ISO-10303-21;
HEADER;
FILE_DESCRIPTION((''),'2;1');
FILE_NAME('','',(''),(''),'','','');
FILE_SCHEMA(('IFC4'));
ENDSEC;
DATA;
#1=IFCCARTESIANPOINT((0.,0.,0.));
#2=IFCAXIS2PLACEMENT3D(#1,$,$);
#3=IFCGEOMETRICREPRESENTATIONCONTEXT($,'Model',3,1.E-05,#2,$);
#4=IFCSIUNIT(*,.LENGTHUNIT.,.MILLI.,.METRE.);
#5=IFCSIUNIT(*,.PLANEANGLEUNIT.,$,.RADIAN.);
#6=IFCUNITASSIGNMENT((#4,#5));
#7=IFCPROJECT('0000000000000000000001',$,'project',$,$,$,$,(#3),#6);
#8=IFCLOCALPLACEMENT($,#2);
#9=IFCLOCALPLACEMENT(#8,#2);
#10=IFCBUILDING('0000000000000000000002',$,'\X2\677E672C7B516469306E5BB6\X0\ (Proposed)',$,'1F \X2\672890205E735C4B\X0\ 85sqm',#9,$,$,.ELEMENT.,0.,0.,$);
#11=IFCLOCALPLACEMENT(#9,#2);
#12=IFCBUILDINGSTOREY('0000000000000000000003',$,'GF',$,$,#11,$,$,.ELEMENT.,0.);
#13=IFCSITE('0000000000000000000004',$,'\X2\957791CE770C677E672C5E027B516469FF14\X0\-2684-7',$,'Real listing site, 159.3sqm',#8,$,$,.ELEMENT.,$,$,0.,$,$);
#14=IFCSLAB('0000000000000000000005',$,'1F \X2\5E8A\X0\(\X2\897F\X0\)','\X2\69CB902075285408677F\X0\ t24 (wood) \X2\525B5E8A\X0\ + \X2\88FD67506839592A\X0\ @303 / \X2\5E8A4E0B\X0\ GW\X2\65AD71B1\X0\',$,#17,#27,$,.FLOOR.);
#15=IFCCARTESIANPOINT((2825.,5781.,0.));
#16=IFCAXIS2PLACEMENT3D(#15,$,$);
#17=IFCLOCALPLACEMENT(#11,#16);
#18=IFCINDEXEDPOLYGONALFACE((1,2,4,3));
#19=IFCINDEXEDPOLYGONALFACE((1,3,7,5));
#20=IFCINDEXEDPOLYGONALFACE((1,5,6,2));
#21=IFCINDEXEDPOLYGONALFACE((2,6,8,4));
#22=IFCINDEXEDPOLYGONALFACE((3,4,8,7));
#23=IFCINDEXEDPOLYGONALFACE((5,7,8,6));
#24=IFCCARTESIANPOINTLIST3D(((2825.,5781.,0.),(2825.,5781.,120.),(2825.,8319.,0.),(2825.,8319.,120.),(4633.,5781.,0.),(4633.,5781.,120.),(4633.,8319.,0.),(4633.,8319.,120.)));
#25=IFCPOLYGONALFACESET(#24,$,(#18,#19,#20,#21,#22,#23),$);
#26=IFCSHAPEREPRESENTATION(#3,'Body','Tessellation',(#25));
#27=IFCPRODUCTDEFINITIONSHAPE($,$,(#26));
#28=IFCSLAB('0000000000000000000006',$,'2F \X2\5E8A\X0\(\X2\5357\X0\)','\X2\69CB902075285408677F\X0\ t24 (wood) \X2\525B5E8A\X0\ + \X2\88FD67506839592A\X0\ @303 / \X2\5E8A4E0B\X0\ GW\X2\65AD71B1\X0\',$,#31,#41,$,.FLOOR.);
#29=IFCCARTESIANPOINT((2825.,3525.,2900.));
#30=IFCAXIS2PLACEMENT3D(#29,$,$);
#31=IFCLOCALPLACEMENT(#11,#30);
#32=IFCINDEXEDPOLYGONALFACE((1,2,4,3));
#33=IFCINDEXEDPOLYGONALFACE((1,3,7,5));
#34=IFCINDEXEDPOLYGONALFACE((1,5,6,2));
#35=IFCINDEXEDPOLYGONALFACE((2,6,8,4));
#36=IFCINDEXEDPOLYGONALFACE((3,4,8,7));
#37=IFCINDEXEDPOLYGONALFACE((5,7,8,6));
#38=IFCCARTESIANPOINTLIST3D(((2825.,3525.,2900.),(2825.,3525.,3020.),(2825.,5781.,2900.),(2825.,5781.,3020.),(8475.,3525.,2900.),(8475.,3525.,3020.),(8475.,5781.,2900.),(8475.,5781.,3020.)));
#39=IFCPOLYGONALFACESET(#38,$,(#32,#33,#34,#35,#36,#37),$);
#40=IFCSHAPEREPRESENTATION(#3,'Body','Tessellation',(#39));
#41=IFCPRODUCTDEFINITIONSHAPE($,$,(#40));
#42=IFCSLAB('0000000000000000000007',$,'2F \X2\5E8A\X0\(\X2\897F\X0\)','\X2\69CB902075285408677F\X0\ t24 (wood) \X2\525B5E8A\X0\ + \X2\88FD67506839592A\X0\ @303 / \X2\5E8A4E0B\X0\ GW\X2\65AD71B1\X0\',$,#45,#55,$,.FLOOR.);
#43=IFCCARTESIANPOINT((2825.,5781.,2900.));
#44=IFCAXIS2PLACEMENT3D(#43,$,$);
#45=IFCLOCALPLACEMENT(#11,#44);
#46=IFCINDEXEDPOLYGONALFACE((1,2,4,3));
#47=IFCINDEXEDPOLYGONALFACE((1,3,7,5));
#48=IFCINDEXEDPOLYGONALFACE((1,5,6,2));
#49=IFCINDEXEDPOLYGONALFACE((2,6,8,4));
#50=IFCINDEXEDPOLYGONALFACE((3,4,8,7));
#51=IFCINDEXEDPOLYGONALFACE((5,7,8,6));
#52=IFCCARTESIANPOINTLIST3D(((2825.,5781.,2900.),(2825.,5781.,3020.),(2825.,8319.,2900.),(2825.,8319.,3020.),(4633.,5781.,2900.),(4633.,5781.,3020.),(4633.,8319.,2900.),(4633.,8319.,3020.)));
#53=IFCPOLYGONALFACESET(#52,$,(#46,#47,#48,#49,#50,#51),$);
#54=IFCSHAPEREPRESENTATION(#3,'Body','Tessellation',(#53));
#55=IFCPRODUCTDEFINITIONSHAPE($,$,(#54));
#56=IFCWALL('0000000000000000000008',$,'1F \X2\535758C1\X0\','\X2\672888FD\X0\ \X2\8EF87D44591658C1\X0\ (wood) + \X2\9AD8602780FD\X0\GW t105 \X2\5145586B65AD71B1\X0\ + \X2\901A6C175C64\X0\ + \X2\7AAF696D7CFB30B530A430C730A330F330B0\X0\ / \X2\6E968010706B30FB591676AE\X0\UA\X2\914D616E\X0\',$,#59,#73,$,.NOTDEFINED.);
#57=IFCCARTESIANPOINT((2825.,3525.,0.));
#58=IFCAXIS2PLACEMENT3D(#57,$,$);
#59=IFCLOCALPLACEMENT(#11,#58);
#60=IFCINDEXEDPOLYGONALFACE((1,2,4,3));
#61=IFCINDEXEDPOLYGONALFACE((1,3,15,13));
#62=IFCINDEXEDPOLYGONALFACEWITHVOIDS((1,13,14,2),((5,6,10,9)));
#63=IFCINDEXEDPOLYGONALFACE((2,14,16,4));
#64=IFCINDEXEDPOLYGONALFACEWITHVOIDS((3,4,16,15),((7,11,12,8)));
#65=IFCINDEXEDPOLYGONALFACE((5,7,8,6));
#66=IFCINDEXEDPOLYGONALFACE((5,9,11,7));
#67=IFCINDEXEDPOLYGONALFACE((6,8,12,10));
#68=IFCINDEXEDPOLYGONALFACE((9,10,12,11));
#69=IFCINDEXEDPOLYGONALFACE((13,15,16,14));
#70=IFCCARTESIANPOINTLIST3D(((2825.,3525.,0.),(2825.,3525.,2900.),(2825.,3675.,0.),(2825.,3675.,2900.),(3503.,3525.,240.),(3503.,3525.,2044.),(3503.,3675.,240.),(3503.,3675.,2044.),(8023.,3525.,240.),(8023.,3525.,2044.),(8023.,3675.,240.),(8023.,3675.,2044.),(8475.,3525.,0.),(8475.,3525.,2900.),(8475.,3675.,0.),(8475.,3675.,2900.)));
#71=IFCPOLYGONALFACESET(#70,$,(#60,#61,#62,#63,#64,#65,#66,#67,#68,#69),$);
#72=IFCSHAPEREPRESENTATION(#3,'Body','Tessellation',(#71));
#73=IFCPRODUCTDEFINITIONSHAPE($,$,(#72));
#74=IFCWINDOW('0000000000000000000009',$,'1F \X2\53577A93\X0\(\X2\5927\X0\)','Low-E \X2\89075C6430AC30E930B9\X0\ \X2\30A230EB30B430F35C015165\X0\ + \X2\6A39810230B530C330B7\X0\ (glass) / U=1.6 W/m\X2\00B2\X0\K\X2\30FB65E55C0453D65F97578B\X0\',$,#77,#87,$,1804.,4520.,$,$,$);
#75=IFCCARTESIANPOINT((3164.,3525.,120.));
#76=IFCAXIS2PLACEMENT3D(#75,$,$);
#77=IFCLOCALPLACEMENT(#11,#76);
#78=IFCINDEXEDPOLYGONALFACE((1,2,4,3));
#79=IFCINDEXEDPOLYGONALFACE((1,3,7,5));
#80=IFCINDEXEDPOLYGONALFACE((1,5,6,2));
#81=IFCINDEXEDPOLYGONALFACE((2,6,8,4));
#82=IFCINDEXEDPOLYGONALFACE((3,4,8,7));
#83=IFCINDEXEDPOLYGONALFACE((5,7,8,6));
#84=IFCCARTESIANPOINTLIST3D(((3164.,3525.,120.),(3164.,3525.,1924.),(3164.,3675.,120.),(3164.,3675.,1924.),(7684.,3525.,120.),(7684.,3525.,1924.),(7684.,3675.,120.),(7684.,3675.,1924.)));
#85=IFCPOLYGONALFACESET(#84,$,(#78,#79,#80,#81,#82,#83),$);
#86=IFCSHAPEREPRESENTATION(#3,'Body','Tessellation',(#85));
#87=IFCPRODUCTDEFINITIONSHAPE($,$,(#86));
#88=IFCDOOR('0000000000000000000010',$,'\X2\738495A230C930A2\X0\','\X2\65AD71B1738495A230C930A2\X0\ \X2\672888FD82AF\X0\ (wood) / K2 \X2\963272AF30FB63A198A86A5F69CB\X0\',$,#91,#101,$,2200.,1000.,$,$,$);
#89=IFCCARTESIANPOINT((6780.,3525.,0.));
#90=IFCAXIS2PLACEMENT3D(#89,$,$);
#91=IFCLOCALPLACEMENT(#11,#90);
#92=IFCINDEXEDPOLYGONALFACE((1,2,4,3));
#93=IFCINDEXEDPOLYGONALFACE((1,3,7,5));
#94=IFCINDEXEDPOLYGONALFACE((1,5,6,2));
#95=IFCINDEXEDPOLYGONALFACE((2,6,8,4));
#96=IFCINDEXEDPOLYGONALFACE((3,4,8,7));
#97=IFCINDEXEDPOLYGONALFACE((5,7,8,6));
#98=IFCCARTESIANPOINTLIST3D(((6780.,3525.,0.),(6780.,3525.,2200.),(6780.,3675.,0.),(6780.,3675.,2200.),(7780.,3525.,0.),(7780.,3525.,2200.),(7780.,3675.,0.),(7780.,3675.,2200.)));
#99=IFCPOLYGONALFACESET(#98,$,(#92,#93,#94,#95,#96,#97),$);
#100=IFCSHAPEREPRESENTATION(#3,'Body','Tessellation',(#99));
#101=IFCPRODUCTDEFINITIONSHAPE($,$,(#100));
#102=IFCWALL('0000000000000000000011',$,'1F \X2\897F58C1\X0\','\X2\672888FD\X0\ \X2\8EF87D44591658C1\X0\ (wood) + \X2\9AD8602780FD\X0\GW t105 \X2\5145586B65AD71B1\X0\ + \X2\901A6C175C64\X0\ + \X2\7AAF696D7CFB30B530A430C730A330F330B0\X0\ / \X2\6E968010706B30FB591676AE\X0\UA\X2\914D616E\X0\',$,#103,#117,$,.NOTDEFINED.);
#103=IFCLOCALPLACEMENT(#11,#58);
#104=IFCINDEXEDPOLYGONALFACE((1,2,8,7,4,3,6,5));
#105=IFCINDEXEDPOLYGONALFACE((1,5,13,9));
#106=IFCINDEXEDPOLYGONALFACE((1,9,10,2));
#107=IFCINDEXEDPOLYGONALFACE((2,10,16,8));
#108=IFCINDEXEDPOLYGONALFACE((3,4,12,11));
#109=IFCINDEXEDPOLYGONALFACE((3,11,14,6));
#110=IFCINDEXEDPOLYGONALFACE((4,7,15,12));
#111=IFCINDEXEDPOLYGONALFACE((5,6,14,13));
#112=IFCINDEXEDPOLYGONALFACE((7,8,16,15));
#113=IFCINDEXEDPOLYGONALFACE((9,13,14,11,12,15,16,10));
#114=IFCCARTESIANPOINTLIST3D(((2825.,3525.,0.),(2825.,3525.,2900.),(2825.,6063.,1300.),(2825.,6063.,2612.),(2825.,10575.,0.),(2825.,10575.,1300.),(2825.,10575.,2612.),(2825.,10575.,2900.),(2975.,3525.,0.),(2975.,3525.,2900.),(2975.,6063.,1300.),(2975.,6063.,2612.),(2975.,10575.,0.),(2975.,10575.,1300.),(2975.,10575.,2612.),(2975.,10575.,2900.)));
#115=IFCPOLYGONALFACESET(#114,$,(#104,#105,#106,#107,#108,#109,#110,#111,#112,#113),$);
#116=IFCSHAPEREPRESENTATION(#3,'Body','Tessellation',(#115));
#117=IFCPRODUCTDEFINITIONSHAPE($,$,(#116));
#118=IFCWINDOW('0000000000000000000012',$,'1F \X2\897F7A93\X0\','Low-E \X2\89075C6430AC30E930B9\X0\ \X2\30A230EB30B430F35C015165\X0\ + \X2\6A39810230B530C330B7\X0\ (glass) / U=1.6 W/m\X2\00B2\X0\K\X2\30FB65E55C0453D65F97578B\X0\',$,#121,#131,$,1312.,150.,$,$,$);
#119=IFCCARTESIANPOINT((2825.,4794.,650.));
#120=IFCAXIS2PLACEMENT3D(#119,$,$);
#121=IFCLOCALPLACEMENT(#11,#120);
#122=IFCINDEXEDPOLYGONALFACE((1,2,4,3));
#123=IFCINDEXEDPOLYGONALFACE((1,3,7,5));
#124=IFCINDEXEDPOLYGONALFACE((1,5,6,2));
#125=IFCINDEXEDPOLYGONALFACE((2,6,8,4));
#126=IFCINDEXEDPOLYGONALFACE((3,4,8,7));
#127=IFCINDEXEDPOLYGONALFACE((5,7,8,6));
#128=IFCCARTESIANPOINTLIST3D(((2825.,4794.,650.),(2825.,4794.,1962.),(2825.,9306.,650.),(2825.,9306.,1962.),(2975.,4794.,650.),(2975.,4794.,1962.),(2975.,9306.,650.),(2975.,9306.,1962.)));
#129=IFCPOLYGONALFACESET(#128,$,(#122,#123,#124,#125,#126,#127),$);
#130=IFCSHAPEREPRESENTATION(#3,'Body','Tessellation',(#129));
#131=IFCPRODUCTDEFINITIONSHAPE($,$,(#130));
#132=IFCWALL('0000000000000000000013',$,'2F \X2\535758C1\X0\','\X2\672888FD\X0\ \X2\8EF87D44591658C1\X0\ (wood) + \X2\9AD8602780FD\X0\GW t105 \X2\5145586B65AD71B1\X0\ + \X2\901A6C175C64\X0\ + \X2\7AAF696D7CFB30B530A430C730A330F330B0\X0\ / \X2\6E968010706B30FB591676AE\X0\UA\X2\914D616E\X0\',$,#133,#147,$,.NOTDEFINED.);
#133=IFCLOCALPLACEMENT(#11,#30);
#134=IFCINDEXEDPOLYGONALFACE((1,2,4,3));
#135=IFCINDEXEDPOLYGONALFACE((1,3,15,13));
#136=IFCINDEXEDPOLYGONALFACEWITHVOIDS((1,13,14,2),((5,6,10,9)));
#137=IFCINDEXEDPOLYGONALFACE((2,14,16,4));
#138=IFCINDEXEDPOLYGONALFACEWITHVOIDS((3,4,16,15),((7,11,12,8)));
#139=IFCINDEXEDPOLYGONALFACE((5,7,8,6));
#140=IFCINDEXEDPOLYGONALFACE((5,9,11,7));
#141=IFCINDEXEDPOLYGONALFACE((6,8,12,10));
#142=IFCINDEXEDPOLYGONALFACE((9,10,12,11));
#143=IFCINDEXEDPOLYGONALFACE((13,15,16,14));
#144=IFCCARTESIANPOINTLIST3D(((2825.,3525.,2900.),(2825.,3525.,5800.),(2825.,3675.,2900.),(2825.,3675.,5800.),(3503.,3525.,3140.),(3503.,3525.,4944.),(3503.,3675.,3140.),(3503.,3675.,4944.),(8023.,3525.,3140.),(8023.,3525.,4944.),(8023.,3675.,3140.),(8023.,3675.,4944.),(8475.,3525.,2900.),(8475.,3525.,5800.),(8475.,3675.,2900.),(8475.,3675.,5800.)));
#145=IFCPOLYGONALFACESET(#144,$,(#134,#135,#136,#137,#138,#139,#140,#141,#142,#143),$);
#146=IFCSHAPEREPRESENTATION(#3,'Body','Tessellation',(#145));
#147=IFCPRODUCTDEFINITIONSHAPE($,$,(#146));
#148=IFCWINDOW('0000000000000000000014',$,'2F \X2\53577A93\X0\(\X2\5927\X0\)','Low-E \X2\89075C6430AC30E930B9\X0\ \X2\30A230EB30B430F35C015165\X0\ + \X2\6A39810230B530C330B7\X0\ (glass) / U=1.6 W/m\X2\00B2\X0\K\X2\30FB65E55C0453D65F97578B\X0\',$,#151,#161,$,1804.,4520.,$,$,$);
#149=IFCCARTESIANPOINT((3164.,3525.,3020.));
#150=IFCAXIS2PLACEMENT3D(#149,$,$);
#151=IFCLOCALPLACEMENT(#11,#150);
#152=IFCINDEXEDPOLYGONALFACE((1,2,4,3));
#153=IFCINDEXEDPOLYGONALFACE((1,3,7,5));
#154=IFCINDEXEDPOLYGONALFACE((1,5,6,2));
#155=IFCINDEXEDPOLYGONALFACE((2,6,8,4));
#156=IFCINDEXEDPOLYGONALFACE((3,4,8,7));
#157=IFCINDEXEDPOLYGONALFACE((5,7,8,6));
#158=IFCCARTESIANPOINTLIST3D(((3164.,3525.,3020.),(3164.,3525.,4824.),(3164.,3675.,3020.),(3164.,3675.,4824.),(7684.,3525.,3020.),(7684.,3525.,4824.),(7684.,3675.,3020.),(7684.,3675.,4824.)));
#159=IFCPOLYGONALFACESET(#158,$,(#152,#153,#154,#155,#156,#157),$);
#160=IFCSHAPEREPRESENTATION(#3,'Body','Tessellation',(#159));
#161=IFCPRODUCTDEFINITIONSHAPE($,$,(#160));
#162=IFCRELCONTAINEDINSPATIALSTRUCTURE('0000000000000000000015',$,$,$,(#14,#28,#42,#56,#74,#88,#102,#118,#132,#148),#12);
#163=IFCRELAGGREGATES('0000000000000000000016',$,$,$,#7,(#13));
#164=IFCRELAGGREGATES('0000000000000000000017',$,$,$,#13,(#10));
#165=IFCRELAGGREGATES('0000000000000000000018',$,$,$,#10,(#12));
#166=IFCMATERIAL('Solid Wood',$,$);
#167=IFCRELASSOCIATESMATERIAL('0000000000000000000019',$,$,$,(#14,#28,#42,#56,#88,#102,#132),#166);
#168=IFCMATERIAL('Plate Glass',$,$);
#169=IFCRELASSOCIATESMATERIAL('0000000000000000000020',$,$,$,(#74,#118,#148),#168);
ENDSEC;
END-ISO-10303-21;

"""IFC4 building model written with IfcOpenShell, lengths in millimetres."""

from ifc_helpers import new_model, si_unit, frame, frame_2d, origin, place, context, project, spatial, rectangle, extrude, material, element, fill, save


model = new_model("IFC4")

# Units and contexts
model_context = context("Model", 3, precision=1e-05, world=origin())
ifc_project = project(units=[si_unit("LENGTHUNIT", "METRE", prefix="MILLI"), si_unit("PLANEANGLEUNIT", "RADIAN")], contexts=[model_context])

# Site, building, storey
site_placement = place(None, origin())
site = spatial("IfcSite", under=ifc_project, at=site_placement, Name="長野県松本市筑摩４-2684-7", ObjectType="Real listing site, 159.3sqm", CompositionType="ELEMENT", RefElevation=0.0)
building_placement = place(site_placement, origin())
building = spatial("IfcBuilding", under=site, at=building_placement, Name="松本筑摩の家 (Proposed)", ObjectType="1F 木造平屋 85sqm", CompositionType="ELEMENT", ElevationOfRefHeight=0.0, ElevationOfTerrain=0.0)
storey_placement = place(building_placement, origin())
storey = spatial("IfcBuildingStorey", under=building, at=storey_placement, Name="GF", CompositionType="ELEMENT", Elevation=0.0)

# Slabs
ifc_material_1 = material(Name="Solid Wood")
slab_1_placement = place(storey_placement, frame((2825.0, 5781.0, 0.0)))
element("IfcSlab", 1, at=slab_1_placement, inside=storey, material=ifc_material_1, Name="1F 床(西)", Description="構造用合板 t24 (wood) 剛床 + 製材根太 @303 / 床下 GW断熱", PredefinedType="FLOOR", context=model_context, shape_type="SweptSolid", body=[
    extrude(rectangle(XDim=1808.0, YDim=2538.0, at=frame_2d((904.0, 1269.0))), frame((2825.0, 5781.0, 0.0)), (0.0, 0.0, 1.0), 120.0),
])
slab_2_placement = place(storey_placement, frame((2825.0, 3525.0, 2900.0)))
element("IfcSlab", 2, at=slab_2_placement, inside=storey, material=ifc_material_1, Name="2F 床(南)", Description="構造用合板 t24 (wood) 剛床 + 製材根太 @303 / 床下 GW断熱", PredefinedType="FLOOR", context=model_context, shape_type="SweptSolid", body=[
    extrude(rectangle(XDim=5650.0, YDim=2256.0, at=frame_2d((2825.0, 1128.0))), frame((2825.0, 3525.0, 2900.0)), (0.0, 0.0, 1.0), 120.0),
])
slab_3_placement = place(storey_placement, frame((2825.0, 5781.0, 2900.0)))
element("IfcSlab", 3, at=slab_3_placement, inside=storey, material=ifc_material_1, Name="2F 床(西)", Description="構造用合板 t24 (wood) 剛床 + 製材根太 @303 / 床下 GW断熱", PredefinedType="FLOOR", context=model_context, shape_type="SweptSolid", body=[
    extrude(rectangle(XDim=1808.0, YDim=2538.0, at=frame_2d((904.0, 1269.0))), frame((2825.0, 5781.0, 2900.0)), (0.0, 0.0, 1.0), 120.0),
])

# Wall, openings, window, door
wall_1_placement = place(storey_placement, frame((2825.0, 3525.0, 0.0)))
wall_1 = element("IfcWall", 4, at=wall_1_placement, inside=storey, material=ifc_material_1, Name="1F 南壁", Description="木製 軸組外壁 (wood) + 高性能GW t105 充填断熱 + 通気層 + 窯業系サイディング / 準耐火・外皮UA配慮", PredefinedType="NOTDEFINED", context=model_context, shape_type="SweptSolid", body=[
    extrude(rectangle(XDim=5650.0, YDim=150.0, at=frame_2d((2825.0, 75.0))), frame((2825.0, 3525.0, 0.0)), (0.0, 0.0, 1.0), 2900.0),
])
opening_1_placement = place(storey_placement, frame((3164.0, 3525.0, 120.0)))
opening_1 = element("IfcOpeningElement", 5, at=opening_1_placement, cuts=wall_1, PredefinedType="NOTDEFINED", context=model_context, shape_type="SweptSolid", body=[
    extrude(rectangle(XDim=4520.0, YDim=150.0, at=frame_2d((2260.0, 75.0))), frame((3164.0, 3525.0, 120.0)), (0.0, 0.0, 1.0), 1804.0),
])
opening_2_placement = place(storey_placement, frame((6780.0, 3525.0, 0.0)))
opening_2 = element("IfcOpeningElement", 6, at=opening_2_placement, cuts=wall_1, PredefinedType="NOTDEFINED", context=model_context, shape_type="SweptSolid", body=[
    extrude(rectangle(XDim=1000.0, YDim=150.0, at=frame_2d((500.0, 75.0))), frame((6780.0, 3525.0, 0.0)), (0.0, 0.0, 1.0), 2200.0),
])
ifc_material_2 = material(Name="Plate Glass")
window_1_placement = place(storey_placement, frame((3164.0, 3525.0, 120.0)))
window_1 = element("IfcWindow", 7, at=window_1_placement, inside=storey, material=ifc_material_2, Name="1F 南窓(大)", Description="Low-E 複層ガラス アルゴン封入 + 樹脂サッシ (glass) / U=1.6 W/m²K・日射取得型", OverallHeight=1804.0, OverallWidth=4520.0, context=model_context, shape_type="SweptSolid", body=[
    extrude(rectangle(XDim=4520.0, YDim=150.0, at=frame_2d((2260.0, 75.0))), frame((3164.0, 3525.0, 120.0)), (0.0, 0.0, 1.0), 1804.0),
])
fill(opening_1, window_1)
door_placement = place(storey_placement, frame((6780.0, 3525.0, 0.0)))
door = element("IfcDoor", 8, at=door_placement, inside=storey, material=ifc_material_1, Name="玄関ドア", Description="断熱玄関ドア 木製芯 (wood) / K2 防犯・採風機構", OverallHeight=2200.0, OverallWidth=1000.0, context=model_context, shape_type="SweptSolid", body=[
    extrude(rectangle(XDim=1000.0, YDim=150.0, at=frame_2d((500.0, 75.0))), frame((6780.0, 3525.0, 0.0)), (0.0, 0.0, 1.0), 2200.0),
])
fill(opening_2, door)

# Walls, openings, windows
wall_2_placement = place(storey_placement, frame((2825.0, 3525.0, 0.0)))
wall_2 = element("IfcWall", 9, at=wall_2_placement, inside=storey, material=ifc_material_1, Name="1F 西壁", Description="木製 軸組外壁 (wood) + 高性能GW t105 充填断熱 + 通気層 + 窯業系サイディング / 準耐火・外皮UA配慮", PredefinedType="NOTDEFINED", context=model_context, shape_type="SweptSolid", body=[
    extrude(rectangle(XDim=150.0, YDim=7050.0, at=frame_2d((75.0, 3525.0))), frame((2825.0, 3525.0, 0.0)), (0.0, 0.0, 1.0), 2900.0),
])
opening_3_placement = place(storey_placement, frame((2825.0, 4794.0, 650.0)))
opening_3 = element("IfcOpeningElement", 10, at=opening_3_placement, cuts=wall_2, PredefinedType="NOTDEFINED", context=model_context, shape_type="SweptSolid", body=[
    extrude(rectangle(XDim=150.0, YDim=4512.0, at=frame_2d((75.0, 2256.0))), frame((2825.0, 4794.0, 650.0)), (0.0, 0.0, 1.0), 1312.0),
])
window_2_placement = place(storey_placement, frame((2825.0, 4794.0, 650.0)))
window_2 = element("IfcWindow", 11, at=window_2_placement, inside=storey, material=ifc_material_2, Name="1F 西窓", Description="Low-E 複層ガラス アルゴン封入 + 樹脂サッシ (glass) / U=1.6 W/m²K・日射取得型", OverallHeight=1312.0, OverallWidth=150.0, context=model_context, shape_type="SweptSolid", body=[
    extrude(rectangle(XDim=150.0, YDim=4512.0, at=frame_2d((75.0, 2256.0))), frame((2825.0, 4794.0, 650.0)), (0.0, 0.0, 1.0), 1312.0),
])
fill(opening_3, window_2)
wall_3_placement = place(storey_placement, frame((2825.0, 3525.0, 2900.0)))
wall_3 = element("IfcWall", 12, at=wall_3_placement, inside=storey, material=ifc_material_1, Name="2F 南壁", Description="木製 軸組外壁 (wood) + 高性能GW t105 充填断熱 + 通気層 + 窯業系サイディング / 準耐火・外皮UA配慮", PredefinedType="NOTDEFINED", context=model_context, shape_type="SweptSolid", body=[
    extrude(rectangle(XDim=5650.0, YDim=150.0, at=frame_2d((2825.0, 75.0))), frame((2825.0, 3525.0, 2900.0)), (0.0, 0.0, 1.0), 2900.0),
])
opening_4_placement = place(storey_placement, frame((3164.0, 3525.0, 3020.0)))
opening_4 = element("IfcOpeningElement", 13, at=opening_4_placement, cuts=wall_3, PredefinedType="NOTDEFINED", context=model_context, shape_type="SweptSolid", body=[
    extrude(rectangle(XDim=4520.0, YDim=150.0, at=frame_2d((2260.0, 75.0))), frame((3164.0, 3525.0, 3020.0)), (0.0, 0.0, 1.0), 1804.0),
])
window_3_placement = place(storey_placement, frame((3164.0, 3525.0, 3020.0)))
window_3 = element("IfcWindow", 14, at=window_3_placement, inside=storey, material=ifc_material_2, Name="2F 南窓(大)", Description="Low-E 複層ガラス アルゴン封入 + 樹脂サッシ (glass) / U=1.6 W/m²K・日射取得型", OverallHeight=1804.0, OverallWidth=4520.0, context=model_context, shape_type="SweptSolid", body=[
    extrude(rectangle(XDim=4520.0, YDim=150.0, at=frame_2d((2260.0, 75.0))), frame((3164.0, 3525.0, 3020.0)), (0.0, 0.0, 1.0), 1804.0),
])
fill(opening_4, window_3)

save(model, "model.ifc")
